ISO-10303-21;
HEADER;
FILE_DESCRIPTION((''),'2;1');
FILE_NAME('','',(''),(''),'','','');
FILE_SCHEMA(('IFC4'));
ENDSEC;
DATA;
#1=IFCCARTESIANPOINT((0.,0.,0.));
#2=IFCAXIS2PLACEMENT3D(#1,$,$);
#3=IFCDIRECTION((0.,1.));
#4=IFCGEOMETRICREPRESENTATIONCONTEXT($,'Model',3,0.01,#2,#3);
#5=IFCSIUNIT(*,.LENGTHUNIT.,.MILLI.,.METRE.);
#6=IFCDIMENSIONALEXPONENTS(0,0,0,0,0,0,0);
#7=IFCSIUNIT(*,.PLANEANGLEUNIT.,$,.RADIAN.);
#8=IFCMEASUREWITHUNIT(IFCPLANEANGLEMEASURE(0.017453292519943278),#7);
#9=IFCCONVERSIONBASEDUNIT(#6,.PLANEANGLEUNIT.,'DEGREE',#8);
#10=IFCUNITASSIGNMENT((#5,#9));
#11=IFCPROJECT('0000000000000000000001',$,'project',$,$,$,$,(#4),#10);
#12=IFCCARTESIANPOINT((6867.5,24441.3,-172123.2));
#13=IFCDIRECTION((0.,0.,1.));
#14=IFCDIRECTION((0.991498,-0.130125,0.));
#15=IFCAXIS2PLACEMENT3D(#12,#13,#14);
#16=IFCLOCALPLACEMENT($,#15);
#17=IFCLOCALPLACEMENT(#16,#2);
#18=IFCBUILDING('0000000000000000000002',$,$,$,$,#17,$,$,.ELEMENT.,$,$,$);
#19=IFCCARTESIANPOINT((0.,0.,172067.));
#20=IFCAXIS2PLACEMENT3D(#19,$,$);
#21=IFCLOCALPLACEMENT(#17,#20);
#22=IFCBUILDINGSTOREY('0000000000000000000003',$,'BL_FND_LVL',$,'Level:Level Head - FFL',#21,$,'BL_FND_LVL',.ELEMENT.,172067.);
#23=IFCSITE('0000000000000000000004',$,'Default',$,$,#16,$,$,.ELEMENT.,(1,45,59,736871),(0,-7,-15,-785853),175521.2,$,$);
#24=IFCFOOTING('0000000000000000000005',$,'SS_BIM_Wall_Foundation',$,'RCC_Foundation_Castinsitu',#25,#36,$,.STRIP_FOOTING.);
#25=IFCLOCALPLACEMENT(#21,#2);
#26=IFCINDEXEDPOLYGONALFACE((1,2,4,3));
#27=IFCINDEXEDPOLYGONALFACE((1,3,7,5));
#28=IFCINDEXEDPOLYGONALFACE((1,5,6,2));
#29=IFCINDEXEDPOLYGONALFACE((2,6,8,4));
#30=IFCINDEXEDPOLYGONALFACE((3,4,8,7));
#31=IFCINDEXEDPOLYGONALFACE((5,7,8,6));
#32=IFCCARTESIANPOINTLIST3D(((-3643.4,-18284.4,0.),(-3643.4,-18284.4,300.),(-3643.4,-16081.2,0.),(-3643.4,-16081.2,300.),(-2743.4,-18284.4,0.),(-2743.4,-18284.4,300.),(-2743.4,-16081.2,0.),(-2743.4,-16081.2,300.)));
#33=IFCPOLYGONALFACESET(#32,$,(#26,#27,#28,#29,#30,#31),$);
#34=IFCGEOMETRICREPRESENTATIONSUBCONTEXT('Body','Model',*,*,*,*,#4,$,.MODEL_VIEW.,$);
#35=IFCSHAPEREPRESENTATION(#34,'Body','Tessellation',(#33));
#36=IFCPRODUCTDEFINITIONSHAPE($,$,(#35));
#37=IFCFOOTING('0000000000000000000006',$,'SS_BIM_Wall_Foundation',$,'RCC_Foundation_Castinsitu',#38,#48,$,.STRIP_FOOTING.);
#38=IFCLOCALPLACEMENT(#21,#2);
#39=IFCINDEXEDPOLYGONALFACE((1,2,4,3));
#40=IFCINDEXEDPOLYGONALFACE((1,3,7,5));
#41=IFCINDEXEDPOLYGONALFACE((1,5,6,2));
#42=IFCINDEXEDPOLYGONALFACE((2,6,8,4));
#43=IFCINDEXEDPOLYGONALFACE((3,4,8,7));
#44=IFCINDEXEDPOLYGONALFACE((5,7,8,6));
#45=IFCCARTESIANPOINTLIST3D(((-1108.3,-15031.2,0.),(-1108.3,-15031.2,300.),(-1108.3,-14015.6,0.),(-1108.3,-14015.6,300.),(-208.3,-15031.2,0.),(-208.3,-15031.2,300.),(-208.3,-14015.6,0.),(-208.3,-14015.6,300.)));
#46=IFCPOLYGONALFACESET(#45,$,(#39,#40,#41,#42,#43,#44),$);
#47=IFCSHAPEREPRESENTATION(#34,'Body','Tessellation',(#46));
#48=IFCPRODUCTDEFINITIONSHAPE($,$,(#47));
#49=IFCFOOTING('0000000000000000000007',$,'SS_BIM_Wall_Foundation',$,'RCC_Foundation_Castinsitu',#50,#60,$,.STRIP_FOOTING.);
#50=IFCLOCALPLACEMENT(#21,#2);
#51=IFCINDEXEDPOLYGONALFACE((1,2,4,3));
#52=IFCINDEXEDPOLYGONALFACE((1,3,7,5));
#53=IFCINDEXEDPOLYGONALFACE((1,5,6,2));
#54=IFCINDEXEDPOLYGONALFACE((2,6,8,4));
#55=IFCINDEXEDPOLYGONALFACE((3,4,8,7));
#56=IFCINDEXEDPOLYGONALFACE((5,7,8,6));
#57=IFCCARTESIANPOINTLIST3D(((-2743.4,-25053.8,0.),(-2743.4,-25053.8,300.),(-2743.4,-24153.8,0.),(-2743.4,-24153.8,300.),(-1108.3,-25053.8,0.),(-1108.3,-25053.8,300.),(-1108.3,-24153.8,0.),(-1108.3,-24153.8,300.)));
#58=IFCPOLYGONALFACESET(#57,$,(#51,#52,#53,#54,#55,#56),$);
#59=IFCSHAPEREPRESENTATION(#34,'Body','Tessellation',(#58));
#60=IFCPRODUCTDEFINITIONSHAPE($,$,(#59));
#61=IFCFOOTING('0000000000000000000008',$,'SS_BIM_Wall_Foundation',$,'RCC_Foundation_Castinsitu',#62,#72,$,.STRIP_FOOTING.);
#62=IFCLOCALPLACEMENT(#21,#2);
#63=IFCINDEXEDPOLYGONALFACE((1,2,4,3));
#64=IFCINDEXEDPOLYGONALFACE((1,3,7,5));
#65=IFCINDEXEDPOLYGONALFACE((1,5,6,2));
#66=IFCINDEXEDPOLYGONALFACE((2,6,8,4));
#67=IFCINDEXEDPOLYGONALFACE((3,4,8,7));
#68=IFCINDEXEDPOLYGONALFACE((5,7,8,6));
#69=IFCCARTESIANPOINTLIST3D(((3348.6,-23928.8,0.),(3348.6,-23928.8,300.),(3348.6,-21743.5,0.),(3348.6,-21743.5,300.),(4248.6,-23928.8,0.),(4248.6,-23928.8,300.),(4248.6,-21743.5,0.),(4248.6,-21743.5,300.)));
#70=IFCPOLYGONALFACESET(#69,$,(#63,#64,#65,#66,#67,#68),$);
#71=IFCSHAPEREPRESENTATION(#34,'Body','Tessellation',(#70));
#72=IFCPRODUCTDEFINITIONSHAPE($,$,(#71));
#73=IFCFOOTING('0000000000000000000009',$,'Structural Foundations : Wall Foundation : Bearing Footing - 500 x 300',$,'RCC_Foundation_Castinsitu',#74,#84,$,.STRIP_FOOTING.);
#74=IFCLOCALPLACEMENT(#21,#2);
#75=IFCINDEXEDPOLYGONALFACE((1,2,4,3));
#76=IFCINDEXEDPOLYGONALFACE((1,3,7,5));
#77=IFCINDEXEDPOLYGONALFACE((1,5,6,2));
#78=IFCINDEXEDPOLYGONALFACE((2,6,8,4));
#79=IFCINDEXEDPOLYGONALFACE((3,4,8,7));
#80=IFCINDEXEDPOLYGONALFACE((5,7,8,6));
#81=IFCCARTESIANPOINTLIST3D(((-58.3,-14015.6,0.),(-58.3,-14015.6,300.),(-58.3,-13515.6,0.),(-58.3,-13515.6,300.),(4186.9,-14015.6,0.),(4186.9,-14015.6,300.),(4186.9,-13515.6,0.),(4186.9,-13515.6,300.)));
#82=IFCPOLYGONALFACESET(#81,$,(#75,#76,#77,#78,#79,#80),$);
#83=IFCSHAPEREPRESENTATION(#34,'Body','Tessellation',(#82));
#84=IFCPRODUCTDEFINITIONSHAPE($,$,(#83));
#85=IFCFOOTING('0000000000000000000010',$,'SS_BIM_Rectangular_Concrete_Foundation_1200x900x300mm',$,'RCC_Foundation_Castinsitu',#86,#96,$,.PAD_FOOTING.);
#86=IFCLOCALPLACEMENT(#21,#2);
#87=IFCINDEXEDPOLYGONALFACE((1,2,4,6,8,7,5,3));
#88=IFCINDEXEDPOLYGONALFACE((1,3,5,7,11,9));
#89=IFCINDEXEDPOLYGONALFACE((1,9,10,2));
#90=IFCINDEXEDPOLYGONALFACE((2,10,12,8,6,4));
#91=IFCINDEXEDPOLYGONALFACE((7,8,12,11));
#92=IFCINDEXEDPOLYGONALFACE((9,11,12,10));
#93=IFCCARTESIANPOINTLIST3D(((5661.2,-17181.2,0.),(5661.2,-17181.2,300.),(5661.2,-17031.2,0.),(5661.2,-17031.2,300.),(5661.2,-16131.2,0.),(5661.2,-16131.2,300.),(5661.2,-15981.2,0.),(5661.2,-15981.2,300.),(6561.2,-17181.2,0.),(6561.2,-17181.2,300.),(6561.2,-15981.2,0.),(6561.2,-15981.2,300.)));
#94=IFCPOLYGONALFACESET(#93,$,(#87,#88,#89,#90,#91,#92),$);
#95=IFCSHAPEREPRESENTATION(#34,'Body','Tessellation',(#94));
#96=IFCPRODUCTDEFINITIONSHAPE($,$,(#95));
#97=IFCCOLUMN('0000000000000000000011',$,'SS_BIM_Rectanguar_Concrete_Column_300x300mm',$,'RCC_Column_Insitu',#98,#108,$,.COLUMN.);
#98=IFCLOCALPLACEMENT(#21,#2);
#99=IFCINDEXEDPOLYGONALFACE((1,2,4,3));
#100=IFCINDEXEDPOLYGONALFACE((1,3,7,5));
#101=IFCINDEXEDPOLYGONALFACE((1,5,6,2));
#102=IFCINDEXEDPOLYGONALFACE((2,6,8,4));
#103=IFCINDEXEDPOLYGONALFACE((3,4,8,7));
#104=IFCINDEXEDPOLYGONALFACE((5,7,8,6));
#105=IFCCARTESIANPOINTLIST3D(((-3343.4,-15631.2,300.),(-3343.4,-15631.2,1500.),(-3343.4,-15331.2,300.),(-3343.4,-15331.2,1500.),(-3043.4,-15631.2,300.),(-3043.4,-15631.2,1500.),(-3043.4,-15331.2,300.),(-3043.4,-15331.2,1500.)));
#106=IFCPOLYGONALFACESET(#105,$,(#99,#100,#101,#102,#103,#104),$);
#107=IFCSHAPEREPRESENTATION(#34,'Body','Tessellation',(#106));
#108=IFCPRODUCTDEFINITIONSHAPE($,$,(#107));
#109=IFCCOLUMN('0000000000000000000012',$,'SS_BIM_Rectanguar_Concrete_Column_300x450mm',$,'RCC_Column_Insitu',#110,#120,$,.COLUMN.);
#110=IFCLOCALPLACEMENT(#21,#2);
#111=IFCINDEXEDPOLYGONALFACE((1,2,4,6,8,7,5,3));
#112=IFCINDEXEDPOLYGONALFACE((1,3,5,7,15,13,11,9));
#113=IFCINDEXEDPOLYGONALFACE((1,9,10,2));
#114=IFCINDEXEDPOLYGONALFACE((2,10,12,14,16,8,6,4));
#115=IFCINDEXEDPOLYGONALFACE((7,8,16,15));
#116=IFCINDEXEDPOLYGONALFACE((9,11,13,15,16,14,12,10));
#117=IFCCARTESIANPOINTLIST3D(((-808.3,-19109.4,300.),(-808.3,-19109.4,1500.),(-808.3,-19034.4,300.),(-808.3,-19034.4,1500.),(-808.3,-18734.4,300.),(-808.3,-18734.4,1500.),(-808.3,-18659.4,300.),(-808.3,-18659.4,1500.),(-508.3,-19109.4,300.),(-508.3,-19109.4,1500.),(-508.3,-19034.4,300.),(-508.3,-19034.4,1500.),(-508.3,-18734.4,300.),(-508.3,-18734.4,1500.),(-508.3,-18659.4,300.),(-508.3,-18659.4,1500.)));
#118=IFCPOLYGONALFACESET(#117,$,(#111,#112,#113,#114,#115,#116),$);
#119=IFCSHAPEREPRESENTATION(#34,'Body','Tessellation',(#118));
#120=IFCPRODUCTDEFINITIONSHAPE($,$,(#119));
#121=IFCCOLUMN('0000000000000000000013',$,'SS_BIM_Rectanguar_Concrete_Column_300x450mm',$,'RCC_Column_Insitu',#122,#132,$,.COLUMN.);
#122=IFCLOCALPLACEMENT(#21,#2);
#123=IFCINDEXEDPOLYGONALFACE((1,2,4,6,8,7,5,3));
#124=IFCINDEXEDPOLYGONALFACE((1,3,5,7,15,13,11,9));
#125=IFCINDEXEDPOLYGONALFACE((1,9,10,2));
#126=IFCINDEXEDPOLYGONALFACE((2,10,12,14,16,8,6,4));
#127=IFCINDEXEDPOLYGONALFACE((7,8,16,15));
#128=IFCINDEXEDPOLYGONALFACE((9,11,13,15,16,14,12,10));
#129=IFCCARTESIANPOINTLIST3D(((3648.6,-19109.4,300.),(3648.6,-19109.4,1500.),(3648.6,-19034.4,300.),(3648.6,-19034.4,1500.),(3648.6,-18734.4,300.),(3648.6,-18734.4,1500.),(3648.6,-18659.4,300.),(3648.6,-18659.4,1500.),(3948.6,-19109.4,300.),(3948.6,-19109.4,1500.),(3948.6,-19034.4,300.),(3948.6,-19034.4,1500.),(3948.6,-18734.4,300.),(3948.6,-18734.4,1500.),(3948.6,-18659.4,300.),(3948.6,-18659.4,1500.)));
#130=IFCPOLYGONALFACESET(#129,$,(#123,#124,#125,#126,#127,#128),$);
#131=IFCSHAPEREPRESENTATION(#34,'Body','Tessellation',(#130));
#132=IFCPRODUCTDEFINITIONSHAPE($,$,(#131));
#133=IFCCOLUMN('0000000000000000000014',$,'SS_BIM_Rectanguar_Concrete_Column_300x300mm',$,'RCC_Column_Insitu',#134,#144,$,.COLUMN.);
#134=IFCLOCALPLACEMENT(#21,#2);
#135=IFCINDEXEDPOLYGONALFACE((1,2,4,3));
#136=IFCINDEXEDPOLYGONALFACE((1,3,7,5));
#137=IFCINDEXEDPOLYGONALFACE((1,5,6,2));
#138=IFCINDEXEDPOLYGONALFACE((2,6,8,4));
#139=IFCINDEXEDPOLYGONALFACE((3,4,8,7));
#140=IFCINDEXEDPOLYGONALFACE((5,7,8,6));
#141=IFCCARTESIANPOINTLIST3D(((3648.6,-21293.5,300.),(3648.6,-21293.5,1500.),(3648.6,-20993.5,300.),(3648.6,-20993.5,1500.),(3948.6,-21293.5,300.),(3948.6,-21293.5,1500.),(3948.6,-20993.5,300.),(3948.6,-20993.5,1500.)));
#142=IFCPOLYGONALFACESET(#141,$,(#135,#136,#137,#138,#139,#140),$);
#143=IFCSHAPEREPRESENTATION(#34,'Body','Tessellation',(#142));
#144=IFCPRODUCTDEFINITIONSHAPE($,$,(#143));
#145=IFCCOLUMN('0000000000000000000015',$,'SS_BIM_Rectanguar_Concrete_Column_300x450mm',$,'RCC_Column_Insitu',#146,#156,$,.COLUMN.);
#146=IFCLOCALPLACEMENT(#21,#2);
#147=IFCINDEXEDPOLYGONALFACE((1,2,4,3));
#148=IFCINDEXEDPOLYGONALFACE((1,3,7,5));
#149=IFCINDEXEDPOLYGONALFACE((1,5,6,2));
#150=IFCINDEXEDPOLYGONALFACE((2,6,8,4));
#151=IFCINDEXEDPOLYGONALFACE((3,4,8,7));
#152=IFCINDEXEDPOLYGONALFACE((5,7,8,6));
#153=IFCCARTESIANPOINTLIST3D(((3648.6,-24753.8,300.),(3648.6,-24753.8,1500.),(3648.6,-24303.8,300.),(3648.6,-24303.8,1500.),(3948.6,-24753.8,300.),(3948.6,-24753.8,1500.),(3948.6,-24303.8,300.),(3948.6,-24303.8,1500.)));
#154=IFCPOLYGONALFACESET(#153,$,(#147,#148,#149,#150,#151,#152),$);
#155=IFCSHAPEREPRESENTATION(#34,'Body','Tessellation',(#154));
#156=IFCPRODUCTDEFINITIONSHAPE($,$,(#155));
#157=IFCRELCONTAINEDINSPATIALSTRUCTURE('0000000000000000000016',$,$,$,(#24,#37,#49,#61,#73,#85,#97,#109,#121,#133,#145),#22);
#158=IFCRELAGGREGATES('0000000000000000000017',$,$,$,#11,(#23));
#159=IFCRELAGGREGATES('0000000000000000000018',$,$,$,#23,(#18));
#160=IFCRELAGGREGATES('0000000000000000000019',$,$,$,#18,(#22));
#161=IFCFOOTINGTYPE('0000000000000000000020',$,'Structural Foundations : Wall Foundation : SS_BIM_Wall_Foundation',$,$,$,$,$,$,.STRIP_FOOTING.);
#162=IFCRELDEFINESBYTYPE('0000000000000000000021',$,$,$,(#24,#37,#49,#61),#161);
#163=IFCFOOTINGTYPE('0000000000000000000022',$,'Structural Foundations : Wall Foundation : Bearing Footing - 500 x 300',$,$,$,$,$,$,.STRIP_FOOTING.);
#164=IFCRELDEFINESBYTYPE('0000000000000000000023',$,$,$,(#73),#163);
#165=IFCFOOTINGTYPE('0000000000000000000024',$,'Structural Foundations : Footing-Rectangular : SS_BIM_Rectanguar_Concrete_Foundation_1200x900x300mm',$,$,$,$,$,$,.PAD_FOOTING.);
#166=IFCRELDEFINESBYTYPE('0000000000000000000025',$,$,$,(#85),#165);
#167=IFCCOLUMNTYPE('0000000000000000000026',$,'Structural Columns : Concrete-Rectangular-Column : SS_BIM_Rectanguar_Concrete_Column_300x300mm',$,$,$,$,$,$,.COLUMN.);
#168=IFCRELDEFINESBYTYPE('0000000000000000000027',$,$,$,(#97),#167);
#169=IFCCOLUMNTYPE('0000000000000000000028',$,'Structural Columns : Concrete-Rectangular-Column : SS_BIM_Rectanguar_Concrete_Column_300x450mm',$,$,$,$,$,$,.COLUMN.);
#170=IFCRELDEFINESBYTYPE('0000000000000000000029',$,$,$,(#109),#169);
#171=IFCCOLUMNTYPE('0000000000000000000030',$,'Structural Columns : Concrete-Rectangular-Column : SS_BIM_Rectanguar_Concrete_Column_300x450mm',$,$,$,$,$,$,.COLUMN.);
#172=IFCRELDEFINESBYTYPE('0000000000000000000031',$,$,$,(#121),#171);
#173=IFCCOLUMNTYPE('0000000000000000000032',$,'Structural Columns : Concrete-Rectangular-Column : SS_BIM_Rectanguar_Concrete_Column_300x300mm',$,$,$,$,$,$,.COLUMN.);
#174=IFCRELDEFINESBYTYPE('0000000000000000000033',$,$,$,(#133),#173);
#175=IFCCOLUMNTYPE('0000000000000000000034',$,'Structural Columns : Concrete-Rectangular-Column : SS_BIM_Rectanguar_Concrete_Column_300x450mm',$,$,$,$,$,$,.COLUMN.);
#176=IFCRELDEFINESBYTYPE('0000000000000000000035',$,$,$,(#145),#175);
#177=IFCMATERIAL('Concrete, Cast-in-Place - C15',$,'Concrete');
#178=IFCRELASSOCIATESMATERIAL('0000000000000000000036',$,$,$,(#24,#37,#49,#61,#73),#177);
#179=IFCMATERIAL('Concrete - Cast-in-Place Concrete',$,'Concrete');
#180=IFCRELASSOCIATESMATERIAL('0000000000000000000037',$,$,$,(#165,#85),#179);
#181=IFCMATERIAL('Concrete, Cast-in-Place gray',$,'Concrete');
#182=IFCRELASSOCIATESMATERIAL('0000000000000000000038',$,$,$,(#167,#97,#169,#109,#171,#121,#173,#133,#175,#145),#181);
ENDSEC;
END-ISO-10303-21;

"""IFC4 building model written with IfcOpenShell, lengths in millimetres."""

from ifc_helpers import new_model, entity, si_unit, converted_unit, direction, frame, origin, place, context, subcontext, project, spatial, indexed_curve, outline, extrude, source, transform, mapped, material, type_object, type_shapes, element, save


model = new_model("IFC4")

# Units and contexts
model_context = context("Model", 3, precision=0.01, world=origin(), true_north=direction((0.0, 1.0)))
body_context = subcontext(model_context, "Body", "Model", "MODEL_VIEW")
ifc_project = project(units=[si_unit("LENGTHUNIT", "METRE", prefix="MILLI"), converted_unit("PLANEANGLEUNIT", "DEGREE", entity("IfcPlaneAngleMeasure", 0.017453292519943278), si_unit("PLANEANGLEUNIT", "RADIAN"), dimensions=[0, 0, 0, 0, 0, 0, 0])], contexts=[model_context])

# Site, building, storey
site_placement = place(None, frame((6867.5, 24441.3, -172123.2), z_axis=(0.0, 0.0, 1.0), x_axis=(0.991498, -0.130125, 0.0)))
site = spatial("IfcSite", under=ifc_project, at=site_placement, Name="Default", CompositionType="ELEMENT", RefLatitude=(1, 45, 59, 736871), RefLongitude=(0, -7, -15, -785853), RefElevation=175521.2)
building_placement = place(site_placement, origin())
building = spatial("IfcBuilding", under=site, at=building_placement, CompositionType="ELEMENT")
storey_placement = place(building_placement, frame((0.0, 0.0, 172067.0)))
storey = spatial("IfcBuildingStorey", under=building, at=storey_placement, Name="BL_FND_LVL", ObjectType="Level:Level Head - FFL", LongName="BL_FND_LVL", CompositionType="ELEMENT", Elevation=172067.0)

# Footings
ifc_material_1 = material(Name="Concrete - Cast-in-Place Concrete", Category="Concrete")
ifc_material_2 = material(Name="Concrete, Cast-in-Place - C15", Category="Concrete")
footing_type_1 = type_object("IfcFootingType", Name="Structural Foundations : Wall Foundation : SS_BIM_Wall_Foundation", PredefinedType="STRIP_FOOTING")
footing_1_placement = place(storey_placement, origin())
element("IfcFooting", 1, at=footing_1_placement, inside=storey, type_object=footing_type_1, material=ifc_material_2, Name="SS_BIM_Wall_Foundation", ObjectType="RCC_Foundation_Castinsitu", PredefinedType="STRIP_FOOTING", context=body_context, shape_type="SweptSolid", body=[
    extrude(outline(indexed_curve([(-1101.6, -450.0), (1101.6, -450.0), (1101.6, 450.0), (-1101.6, 450.0), (-1101.6, -450.0)], self_intersect=False)), frame((-3193.4, -17182.8, 0.0), z_axis=(0.0, 0.0, 1.0), x_axis=(0.0, -1.0, 0.0)), (0.0, 0.0, 1.0), 300.0),
])
footing_2_placement = place(storey_placement, origin())
element("IfcFooting", 2, at=footing_2_placement, inside=storey, type_object=footing_type_1, material=ifc_material_2, Name="SS_BIM_Wall_Foundation", ObjectType="RCC_Foundation_Castinsitu", PredefinedType="STRIP_FOOTING", context=body_context, shape_type="SweptSolid", body=[
    extrude(outline(indexed_curve([(-507.8, -450.0), (507.8, -450.0), (507.8, 450.0), (-507.8, 450.0), (-507.8, -450.0)], self_intersect=False)), frame((-658.3, -14523.4, 0.0), z_axis=(0.0, 0.0, 1.0), x_axis=(0.0, -1.0, 0.0)), (0.0, 0.0, 1.0), 300.0),
])
footing_3_placement = place(storey_placement, origin())
element("IfcFooting", 3, at=footing_3_placement, inside=storey, type_object=footing_type_1, material=ifc_material_2, Name="SS_BIM_Wall_Foundation", ObjectType="RCC_Foundation_Castinsitu", PredefinedType="STRIP_FOOTING", context=body_context, shape_type="SweptSolid", body=[
    extrude(outline(indexed_curve([(-817.5, -450.0), (817.5, -450.0), (817.5, 450.0), (-817.5, 450.0), (-817.5, -450.0)], self_intersect=False)), frame((-1925.8, -24603.8, 0.0)), (0.0, 0.0, 1.0), 300.0),
])
footing_4_placement = place(storey_placement, origin())
element("IfcFooting", 4, at=footing_4_placement, inside=storey, type_object=footing_type_1, material=ifc_material_2, Name="SS_BIM_Wall_Foundation", ObjectType="RCC_Foundation_Castinsitu", PredefinedType="STRIP_FOOTING", context=body_context, shape_type="SweptSolid", body=[
    extrude(outline(indexed_curve([(-1092.7, -450.0), (1092.7, -450.0), (1092.7, 450.0), (-1092.7, 450.0), (-1092.7, -450.0)], self_intersect=False)), frame((3798.6, -22836.1, 0.0), z_axis=(0.0, 0.0, 1.0), x_axis=(0.0, -1.0, 0.0)), (0.0, 0.0, 1.0), 300.0),
])
footing_type_2 = type_object("IfcFootingType", Name="Structural Foundations : Wall Foundation : Bearing Footing - 500 x 300", PredefinedType="STRIP_FOOTING")
footing_5_placement = place(storey_placement, origin())
element("IfcFooting", 5, at=footing_5_placement, inside=storey, type_object=footing_type_2, material=ifc_material_2, Name="Structural Foundations : Wall Foundation : Bearing Footing - 500 x 300", ObjectType="RCC_Foundation_Castinsitu", PredefinedType="STRIP_FOOTING", context=body_context, shape_type="SweptSolid", body=[
    extrude(outline(indexed_curve([(-2122.6, -250.0), (2122.6, -250.0), (2122.6, 250.0), (-2122.6, 250.0), (-2122.6, -250.0)], self_intersect=False)), frame((2064.3, -13765.6, 0.0)), (0.0, 0.0, 1.0), 300.0),
])
footing_type_3 = type_object("IfcFootingType", Name="Structural Foundations : Footing-Rectangular : SS_BIM_Rectanguar_Concrete_Foundation_1200x900x300mm", PredefinedType="PAD_FOOTING", material=ifc_material_1)
shared_shape_1 = source(origin(), body_context, "Body", "SweptSolid", [
    extrude(outline(indexed_curve([(-600.0, -600.0), (300.0, -600.0), (300.0, -450.0), (300.0, 450.0), (300.0, 600.0), (-600.0, 600.0), (-600.0, -600.0)], self_intersect=False)), frame((5961.2, -16581.2, 172067.0), z_axis=(0.0, 0.0, 1.0), x_axis=(-1.0, 0.0, 0.0)), (0.0, 0.0, 1.0), 300.0),
])
type_shapes(footing_type_3, [shared_shape_1])
footing_6_placement = place(storey_placement, frame((0.0, 0.0, -172067.0)))
element("IfcFooting", 6, at=footing_6_placement, inside=storey, type_object=footing_type_3, material=ifc_material_1, Name="SS_BIM_Rectangular_Concrete_Foundation_1200x900x300mm", ObjectType="RCC_Foundation_Castinsitu", PredefinedType="PAD_FOOTING", context=body_context, shape_type="MappedRepresentation", body=[
    mapped(shared_shape_1, transform((0.0, 0.0, 0.0), scale=1.0)),
])

# Columns
ifc_material_3 = material(Name="Concrete, Cast-in-Place gray", Category="Concrete")
column_type_1 = type_object("IfcColumnType", Name="Structural Columns : Concrete-Rectangular-Column : SS_BIM_Rectanguar_Concrete_Column_300x300mm", PredefinedType="COLUMN", material=ifc_material_3)
shared_shape_2 = source(origin(), body_context, "Body", "SweptSolid", [
    extrude(outline(indexed_curve([(-150.0, -150.0), (150.0, -150.0), (150.0, 150.0), (-150.0, 150.0), (-150.0, -150.0)], self_intersect=False)), frame((-3193.4, -15481.2, 172367.0), z_axis=(0.0, 0.0, 1.0), x_axis=(-1.0, 0.0, 0.0)), (0.0, 0.0, 1.0), 1200.0),
])
type_shapes(column_type_1, [shared_shape_2])
column_1_placement = place(storey_placement, frame((0.0, 0.0, -172067.0)))
element("IfcColumn", 7, at=column_1_placement, inside=storey, type_object=column_type_1, material=ifc_material_3, Name="SS_BIM_Rectanguar_Concrete_Column_300x300mm", ObjectType="RCC_Column_Insitu", PredefinedType="COLUMN", context=body_context, shape_type="MappedRepresentation", body=[
    mapped(shared_shape_2, transform((0.0, 0.0, 0.0), scale=1.0)),
])
column_type_2 = type_object("IfcColumnType", Name="Structural Columns : Concrete-Rectangular-Column : SS_BIM_Rectanguar_Concrete_Column_300x450mm", PredefinedType="COLUMN", material=ifc_material_3)
shared_shape_3 = source(origin(), body_context, "Body", "SweptSolid", [
    extrude(outline(indexed_curve([(-150.0, -225.0), (150.0, -225.0), (150.0, -150.0), (150.0, 150.0), (150.0, 225.0), (-150.0, 225.0), (-150.0, 150.0), (-150.0, -150.0), (-150.0, -225.0)], self_intersect=False)), frame((-658.3, -18884.4, 172367.0), z_axis=(0.0, 0.0, 1.0), x_axis=(-1.0, 0.0, 0.0)), (0.0, 0.0, 1.0), 1200.0),
])
type_shapes(column_type_2, [shared_shape_3])
column_2_placement = place(storey_placement, frame((0.0, 0.0, -172067.0)))
element("IfcColumn", 8, at=column_2_placement, inside=storey, type_object=column_type_2, material=ifc_material_3, Name="SS_BIM_Rectanguar_Concrete_Column_300x450mm", ObjectType="RCC_Column_Insitu", PredefinedType="COLUMN", context=body_context, shape_type="MappedRepresentation", body=[
    mapped(shared_shape_3, transform((0.0, 0.0, 0.0), scale=1.0)),
])
column_type_3 = type_object("IfcColumnType", Name="Structural Columns : Concrete-Rectangular-Column : SS_BIM_Rectanguar_Concrete_Column_300x450mm", PredefinedType="COLUMN", material=ifc_material_3)
shared_shape_4 = source(origin(), body_context, "Body", "SweptSolid", [
    extrude(outline(indexed_curve([(-150.0, -225.0), (150.0, -225.0), (150.0, -150.0), (150.0, 150.0), (150.0, 225.0), (-150.0, 225.0), (-150.0, 150.0), (-150.0, -150.0), (-150.0, -225.0)], self_intersect=False)), frame((3798.6, -18884.4, 172367.0), z_axis=(0.0, 0.0, 1.0), x_axis=(-1.0, 0.0, 0.0)), (0.0, 0.0, 1.0), 1200.0),
])
type_shapes(column_type_3, [shared_shape_4])
column_3_placement = place(storey_placement, frame((0.0, 0.0, -172067.0)))
element("IfcColumn", 9, at=column_3_placement, inside=storey, type_object=column_type_3, material=ifc_material_3, Name="SS_BIM_Rectanguar_Concrete_Column_300x450mm", ObjectType="RCC_Column_Insitu", PredefinedType="COLUMN", context=body_context, shape_type="MappedRepresentation", body=[
    mapped(shared_shape_4, transform((0.0, 0.0, 0.0), scale=1.0)),
])
column_type_4 = type_object("IfcColumnType", Name="Structural Columns : Concrete-Rectangular-Column : SS_BIM_Rectanguar_Concrete_Column_300x300mm", PredefinedType="COLUMN", material=ifc_material_3)
shared_shape_5 = source(origin(), body_context, "Body", "SweptSolid", [
    extrude(outline(indexed_curve([(-150.0, -150.0), (150.0, -150.0), (150.0, 150.0), (-150.0, 150.0), (-150.0, -150.0)], self_intersect=False)), frame((3798.6, -21143.5, 172367.0), z_axis=(0.0, 0.0, 1.0), x_axis=(-1.0, 0.0, 0.0)), (0.0, 0.0, 1.0), 1200.0),
])
type_shapes(column_type_4, [shared_shape_5])
column_4_placement = place(storey_placement, frame((0.0, 0.0, -172067.0)))
element("IfcColumn", 10, at=column_4_placement, inside=storey, type_object=column_type_4, material=ifc_material_3, Name="SS_BIM_Rectanguar_Concrete_Column_300x300mm", ObjectType="RCC_Column_Insitu", PredefinedType="COLUMN", context=body_context, shape_type="MappedRepresentation", body=[
    mapped(shared_shape_5, transform((0.0, 0.0, 0.0), scale=1.0)),
])
column_type_5 = type_object("IfcColumnType", Name="Structural Columns : Concrete-Rectangular-Column : SS_BIM_Rectanguar_Concrete_Column_300x450mm", PredefinedType="COLUMN", material=ifc_material_3)
shared_shape_6 = source(origin(), body_context, "Body", "SweptSolid", [
    extrude(outline(indexed_curve([(-150.0, -225.0), (150.0, -225.0), (150.0, 225.0), (-150.0, 225.0), (-150.0, -225.0)], self_intersect=False)), frame((3798.6, -24528.8, 172367.0), z_axis=(0.0, 0.0, 1.0), x_axis=(-1.0, 0.0, 0.0)), (0.0, 0.0, 1.0), 1200.0),
])
type_shapes(column_type_5, [shared_shape_6])
column_5_placement = place(storey_placement, frame((0.0, 0.0, -172067.0)))
element("IfcColumn", 11, at=column_5_placement, inside=storey, type_object=column_type_5, material=ifc_material_3, Name="SS_BIM_Rectanguar_Concrete_Column_300x450mm", ObjectType="RCC_Column_Insitu", PredefinedType="COLUMN", context=body_context, shape_type="MappedRepresentation", body=[
    mapped(shared_shape_6, transform((0.0, 0.0, 0.0), scale=1.0)),
])

save(model, "model.ifc")
